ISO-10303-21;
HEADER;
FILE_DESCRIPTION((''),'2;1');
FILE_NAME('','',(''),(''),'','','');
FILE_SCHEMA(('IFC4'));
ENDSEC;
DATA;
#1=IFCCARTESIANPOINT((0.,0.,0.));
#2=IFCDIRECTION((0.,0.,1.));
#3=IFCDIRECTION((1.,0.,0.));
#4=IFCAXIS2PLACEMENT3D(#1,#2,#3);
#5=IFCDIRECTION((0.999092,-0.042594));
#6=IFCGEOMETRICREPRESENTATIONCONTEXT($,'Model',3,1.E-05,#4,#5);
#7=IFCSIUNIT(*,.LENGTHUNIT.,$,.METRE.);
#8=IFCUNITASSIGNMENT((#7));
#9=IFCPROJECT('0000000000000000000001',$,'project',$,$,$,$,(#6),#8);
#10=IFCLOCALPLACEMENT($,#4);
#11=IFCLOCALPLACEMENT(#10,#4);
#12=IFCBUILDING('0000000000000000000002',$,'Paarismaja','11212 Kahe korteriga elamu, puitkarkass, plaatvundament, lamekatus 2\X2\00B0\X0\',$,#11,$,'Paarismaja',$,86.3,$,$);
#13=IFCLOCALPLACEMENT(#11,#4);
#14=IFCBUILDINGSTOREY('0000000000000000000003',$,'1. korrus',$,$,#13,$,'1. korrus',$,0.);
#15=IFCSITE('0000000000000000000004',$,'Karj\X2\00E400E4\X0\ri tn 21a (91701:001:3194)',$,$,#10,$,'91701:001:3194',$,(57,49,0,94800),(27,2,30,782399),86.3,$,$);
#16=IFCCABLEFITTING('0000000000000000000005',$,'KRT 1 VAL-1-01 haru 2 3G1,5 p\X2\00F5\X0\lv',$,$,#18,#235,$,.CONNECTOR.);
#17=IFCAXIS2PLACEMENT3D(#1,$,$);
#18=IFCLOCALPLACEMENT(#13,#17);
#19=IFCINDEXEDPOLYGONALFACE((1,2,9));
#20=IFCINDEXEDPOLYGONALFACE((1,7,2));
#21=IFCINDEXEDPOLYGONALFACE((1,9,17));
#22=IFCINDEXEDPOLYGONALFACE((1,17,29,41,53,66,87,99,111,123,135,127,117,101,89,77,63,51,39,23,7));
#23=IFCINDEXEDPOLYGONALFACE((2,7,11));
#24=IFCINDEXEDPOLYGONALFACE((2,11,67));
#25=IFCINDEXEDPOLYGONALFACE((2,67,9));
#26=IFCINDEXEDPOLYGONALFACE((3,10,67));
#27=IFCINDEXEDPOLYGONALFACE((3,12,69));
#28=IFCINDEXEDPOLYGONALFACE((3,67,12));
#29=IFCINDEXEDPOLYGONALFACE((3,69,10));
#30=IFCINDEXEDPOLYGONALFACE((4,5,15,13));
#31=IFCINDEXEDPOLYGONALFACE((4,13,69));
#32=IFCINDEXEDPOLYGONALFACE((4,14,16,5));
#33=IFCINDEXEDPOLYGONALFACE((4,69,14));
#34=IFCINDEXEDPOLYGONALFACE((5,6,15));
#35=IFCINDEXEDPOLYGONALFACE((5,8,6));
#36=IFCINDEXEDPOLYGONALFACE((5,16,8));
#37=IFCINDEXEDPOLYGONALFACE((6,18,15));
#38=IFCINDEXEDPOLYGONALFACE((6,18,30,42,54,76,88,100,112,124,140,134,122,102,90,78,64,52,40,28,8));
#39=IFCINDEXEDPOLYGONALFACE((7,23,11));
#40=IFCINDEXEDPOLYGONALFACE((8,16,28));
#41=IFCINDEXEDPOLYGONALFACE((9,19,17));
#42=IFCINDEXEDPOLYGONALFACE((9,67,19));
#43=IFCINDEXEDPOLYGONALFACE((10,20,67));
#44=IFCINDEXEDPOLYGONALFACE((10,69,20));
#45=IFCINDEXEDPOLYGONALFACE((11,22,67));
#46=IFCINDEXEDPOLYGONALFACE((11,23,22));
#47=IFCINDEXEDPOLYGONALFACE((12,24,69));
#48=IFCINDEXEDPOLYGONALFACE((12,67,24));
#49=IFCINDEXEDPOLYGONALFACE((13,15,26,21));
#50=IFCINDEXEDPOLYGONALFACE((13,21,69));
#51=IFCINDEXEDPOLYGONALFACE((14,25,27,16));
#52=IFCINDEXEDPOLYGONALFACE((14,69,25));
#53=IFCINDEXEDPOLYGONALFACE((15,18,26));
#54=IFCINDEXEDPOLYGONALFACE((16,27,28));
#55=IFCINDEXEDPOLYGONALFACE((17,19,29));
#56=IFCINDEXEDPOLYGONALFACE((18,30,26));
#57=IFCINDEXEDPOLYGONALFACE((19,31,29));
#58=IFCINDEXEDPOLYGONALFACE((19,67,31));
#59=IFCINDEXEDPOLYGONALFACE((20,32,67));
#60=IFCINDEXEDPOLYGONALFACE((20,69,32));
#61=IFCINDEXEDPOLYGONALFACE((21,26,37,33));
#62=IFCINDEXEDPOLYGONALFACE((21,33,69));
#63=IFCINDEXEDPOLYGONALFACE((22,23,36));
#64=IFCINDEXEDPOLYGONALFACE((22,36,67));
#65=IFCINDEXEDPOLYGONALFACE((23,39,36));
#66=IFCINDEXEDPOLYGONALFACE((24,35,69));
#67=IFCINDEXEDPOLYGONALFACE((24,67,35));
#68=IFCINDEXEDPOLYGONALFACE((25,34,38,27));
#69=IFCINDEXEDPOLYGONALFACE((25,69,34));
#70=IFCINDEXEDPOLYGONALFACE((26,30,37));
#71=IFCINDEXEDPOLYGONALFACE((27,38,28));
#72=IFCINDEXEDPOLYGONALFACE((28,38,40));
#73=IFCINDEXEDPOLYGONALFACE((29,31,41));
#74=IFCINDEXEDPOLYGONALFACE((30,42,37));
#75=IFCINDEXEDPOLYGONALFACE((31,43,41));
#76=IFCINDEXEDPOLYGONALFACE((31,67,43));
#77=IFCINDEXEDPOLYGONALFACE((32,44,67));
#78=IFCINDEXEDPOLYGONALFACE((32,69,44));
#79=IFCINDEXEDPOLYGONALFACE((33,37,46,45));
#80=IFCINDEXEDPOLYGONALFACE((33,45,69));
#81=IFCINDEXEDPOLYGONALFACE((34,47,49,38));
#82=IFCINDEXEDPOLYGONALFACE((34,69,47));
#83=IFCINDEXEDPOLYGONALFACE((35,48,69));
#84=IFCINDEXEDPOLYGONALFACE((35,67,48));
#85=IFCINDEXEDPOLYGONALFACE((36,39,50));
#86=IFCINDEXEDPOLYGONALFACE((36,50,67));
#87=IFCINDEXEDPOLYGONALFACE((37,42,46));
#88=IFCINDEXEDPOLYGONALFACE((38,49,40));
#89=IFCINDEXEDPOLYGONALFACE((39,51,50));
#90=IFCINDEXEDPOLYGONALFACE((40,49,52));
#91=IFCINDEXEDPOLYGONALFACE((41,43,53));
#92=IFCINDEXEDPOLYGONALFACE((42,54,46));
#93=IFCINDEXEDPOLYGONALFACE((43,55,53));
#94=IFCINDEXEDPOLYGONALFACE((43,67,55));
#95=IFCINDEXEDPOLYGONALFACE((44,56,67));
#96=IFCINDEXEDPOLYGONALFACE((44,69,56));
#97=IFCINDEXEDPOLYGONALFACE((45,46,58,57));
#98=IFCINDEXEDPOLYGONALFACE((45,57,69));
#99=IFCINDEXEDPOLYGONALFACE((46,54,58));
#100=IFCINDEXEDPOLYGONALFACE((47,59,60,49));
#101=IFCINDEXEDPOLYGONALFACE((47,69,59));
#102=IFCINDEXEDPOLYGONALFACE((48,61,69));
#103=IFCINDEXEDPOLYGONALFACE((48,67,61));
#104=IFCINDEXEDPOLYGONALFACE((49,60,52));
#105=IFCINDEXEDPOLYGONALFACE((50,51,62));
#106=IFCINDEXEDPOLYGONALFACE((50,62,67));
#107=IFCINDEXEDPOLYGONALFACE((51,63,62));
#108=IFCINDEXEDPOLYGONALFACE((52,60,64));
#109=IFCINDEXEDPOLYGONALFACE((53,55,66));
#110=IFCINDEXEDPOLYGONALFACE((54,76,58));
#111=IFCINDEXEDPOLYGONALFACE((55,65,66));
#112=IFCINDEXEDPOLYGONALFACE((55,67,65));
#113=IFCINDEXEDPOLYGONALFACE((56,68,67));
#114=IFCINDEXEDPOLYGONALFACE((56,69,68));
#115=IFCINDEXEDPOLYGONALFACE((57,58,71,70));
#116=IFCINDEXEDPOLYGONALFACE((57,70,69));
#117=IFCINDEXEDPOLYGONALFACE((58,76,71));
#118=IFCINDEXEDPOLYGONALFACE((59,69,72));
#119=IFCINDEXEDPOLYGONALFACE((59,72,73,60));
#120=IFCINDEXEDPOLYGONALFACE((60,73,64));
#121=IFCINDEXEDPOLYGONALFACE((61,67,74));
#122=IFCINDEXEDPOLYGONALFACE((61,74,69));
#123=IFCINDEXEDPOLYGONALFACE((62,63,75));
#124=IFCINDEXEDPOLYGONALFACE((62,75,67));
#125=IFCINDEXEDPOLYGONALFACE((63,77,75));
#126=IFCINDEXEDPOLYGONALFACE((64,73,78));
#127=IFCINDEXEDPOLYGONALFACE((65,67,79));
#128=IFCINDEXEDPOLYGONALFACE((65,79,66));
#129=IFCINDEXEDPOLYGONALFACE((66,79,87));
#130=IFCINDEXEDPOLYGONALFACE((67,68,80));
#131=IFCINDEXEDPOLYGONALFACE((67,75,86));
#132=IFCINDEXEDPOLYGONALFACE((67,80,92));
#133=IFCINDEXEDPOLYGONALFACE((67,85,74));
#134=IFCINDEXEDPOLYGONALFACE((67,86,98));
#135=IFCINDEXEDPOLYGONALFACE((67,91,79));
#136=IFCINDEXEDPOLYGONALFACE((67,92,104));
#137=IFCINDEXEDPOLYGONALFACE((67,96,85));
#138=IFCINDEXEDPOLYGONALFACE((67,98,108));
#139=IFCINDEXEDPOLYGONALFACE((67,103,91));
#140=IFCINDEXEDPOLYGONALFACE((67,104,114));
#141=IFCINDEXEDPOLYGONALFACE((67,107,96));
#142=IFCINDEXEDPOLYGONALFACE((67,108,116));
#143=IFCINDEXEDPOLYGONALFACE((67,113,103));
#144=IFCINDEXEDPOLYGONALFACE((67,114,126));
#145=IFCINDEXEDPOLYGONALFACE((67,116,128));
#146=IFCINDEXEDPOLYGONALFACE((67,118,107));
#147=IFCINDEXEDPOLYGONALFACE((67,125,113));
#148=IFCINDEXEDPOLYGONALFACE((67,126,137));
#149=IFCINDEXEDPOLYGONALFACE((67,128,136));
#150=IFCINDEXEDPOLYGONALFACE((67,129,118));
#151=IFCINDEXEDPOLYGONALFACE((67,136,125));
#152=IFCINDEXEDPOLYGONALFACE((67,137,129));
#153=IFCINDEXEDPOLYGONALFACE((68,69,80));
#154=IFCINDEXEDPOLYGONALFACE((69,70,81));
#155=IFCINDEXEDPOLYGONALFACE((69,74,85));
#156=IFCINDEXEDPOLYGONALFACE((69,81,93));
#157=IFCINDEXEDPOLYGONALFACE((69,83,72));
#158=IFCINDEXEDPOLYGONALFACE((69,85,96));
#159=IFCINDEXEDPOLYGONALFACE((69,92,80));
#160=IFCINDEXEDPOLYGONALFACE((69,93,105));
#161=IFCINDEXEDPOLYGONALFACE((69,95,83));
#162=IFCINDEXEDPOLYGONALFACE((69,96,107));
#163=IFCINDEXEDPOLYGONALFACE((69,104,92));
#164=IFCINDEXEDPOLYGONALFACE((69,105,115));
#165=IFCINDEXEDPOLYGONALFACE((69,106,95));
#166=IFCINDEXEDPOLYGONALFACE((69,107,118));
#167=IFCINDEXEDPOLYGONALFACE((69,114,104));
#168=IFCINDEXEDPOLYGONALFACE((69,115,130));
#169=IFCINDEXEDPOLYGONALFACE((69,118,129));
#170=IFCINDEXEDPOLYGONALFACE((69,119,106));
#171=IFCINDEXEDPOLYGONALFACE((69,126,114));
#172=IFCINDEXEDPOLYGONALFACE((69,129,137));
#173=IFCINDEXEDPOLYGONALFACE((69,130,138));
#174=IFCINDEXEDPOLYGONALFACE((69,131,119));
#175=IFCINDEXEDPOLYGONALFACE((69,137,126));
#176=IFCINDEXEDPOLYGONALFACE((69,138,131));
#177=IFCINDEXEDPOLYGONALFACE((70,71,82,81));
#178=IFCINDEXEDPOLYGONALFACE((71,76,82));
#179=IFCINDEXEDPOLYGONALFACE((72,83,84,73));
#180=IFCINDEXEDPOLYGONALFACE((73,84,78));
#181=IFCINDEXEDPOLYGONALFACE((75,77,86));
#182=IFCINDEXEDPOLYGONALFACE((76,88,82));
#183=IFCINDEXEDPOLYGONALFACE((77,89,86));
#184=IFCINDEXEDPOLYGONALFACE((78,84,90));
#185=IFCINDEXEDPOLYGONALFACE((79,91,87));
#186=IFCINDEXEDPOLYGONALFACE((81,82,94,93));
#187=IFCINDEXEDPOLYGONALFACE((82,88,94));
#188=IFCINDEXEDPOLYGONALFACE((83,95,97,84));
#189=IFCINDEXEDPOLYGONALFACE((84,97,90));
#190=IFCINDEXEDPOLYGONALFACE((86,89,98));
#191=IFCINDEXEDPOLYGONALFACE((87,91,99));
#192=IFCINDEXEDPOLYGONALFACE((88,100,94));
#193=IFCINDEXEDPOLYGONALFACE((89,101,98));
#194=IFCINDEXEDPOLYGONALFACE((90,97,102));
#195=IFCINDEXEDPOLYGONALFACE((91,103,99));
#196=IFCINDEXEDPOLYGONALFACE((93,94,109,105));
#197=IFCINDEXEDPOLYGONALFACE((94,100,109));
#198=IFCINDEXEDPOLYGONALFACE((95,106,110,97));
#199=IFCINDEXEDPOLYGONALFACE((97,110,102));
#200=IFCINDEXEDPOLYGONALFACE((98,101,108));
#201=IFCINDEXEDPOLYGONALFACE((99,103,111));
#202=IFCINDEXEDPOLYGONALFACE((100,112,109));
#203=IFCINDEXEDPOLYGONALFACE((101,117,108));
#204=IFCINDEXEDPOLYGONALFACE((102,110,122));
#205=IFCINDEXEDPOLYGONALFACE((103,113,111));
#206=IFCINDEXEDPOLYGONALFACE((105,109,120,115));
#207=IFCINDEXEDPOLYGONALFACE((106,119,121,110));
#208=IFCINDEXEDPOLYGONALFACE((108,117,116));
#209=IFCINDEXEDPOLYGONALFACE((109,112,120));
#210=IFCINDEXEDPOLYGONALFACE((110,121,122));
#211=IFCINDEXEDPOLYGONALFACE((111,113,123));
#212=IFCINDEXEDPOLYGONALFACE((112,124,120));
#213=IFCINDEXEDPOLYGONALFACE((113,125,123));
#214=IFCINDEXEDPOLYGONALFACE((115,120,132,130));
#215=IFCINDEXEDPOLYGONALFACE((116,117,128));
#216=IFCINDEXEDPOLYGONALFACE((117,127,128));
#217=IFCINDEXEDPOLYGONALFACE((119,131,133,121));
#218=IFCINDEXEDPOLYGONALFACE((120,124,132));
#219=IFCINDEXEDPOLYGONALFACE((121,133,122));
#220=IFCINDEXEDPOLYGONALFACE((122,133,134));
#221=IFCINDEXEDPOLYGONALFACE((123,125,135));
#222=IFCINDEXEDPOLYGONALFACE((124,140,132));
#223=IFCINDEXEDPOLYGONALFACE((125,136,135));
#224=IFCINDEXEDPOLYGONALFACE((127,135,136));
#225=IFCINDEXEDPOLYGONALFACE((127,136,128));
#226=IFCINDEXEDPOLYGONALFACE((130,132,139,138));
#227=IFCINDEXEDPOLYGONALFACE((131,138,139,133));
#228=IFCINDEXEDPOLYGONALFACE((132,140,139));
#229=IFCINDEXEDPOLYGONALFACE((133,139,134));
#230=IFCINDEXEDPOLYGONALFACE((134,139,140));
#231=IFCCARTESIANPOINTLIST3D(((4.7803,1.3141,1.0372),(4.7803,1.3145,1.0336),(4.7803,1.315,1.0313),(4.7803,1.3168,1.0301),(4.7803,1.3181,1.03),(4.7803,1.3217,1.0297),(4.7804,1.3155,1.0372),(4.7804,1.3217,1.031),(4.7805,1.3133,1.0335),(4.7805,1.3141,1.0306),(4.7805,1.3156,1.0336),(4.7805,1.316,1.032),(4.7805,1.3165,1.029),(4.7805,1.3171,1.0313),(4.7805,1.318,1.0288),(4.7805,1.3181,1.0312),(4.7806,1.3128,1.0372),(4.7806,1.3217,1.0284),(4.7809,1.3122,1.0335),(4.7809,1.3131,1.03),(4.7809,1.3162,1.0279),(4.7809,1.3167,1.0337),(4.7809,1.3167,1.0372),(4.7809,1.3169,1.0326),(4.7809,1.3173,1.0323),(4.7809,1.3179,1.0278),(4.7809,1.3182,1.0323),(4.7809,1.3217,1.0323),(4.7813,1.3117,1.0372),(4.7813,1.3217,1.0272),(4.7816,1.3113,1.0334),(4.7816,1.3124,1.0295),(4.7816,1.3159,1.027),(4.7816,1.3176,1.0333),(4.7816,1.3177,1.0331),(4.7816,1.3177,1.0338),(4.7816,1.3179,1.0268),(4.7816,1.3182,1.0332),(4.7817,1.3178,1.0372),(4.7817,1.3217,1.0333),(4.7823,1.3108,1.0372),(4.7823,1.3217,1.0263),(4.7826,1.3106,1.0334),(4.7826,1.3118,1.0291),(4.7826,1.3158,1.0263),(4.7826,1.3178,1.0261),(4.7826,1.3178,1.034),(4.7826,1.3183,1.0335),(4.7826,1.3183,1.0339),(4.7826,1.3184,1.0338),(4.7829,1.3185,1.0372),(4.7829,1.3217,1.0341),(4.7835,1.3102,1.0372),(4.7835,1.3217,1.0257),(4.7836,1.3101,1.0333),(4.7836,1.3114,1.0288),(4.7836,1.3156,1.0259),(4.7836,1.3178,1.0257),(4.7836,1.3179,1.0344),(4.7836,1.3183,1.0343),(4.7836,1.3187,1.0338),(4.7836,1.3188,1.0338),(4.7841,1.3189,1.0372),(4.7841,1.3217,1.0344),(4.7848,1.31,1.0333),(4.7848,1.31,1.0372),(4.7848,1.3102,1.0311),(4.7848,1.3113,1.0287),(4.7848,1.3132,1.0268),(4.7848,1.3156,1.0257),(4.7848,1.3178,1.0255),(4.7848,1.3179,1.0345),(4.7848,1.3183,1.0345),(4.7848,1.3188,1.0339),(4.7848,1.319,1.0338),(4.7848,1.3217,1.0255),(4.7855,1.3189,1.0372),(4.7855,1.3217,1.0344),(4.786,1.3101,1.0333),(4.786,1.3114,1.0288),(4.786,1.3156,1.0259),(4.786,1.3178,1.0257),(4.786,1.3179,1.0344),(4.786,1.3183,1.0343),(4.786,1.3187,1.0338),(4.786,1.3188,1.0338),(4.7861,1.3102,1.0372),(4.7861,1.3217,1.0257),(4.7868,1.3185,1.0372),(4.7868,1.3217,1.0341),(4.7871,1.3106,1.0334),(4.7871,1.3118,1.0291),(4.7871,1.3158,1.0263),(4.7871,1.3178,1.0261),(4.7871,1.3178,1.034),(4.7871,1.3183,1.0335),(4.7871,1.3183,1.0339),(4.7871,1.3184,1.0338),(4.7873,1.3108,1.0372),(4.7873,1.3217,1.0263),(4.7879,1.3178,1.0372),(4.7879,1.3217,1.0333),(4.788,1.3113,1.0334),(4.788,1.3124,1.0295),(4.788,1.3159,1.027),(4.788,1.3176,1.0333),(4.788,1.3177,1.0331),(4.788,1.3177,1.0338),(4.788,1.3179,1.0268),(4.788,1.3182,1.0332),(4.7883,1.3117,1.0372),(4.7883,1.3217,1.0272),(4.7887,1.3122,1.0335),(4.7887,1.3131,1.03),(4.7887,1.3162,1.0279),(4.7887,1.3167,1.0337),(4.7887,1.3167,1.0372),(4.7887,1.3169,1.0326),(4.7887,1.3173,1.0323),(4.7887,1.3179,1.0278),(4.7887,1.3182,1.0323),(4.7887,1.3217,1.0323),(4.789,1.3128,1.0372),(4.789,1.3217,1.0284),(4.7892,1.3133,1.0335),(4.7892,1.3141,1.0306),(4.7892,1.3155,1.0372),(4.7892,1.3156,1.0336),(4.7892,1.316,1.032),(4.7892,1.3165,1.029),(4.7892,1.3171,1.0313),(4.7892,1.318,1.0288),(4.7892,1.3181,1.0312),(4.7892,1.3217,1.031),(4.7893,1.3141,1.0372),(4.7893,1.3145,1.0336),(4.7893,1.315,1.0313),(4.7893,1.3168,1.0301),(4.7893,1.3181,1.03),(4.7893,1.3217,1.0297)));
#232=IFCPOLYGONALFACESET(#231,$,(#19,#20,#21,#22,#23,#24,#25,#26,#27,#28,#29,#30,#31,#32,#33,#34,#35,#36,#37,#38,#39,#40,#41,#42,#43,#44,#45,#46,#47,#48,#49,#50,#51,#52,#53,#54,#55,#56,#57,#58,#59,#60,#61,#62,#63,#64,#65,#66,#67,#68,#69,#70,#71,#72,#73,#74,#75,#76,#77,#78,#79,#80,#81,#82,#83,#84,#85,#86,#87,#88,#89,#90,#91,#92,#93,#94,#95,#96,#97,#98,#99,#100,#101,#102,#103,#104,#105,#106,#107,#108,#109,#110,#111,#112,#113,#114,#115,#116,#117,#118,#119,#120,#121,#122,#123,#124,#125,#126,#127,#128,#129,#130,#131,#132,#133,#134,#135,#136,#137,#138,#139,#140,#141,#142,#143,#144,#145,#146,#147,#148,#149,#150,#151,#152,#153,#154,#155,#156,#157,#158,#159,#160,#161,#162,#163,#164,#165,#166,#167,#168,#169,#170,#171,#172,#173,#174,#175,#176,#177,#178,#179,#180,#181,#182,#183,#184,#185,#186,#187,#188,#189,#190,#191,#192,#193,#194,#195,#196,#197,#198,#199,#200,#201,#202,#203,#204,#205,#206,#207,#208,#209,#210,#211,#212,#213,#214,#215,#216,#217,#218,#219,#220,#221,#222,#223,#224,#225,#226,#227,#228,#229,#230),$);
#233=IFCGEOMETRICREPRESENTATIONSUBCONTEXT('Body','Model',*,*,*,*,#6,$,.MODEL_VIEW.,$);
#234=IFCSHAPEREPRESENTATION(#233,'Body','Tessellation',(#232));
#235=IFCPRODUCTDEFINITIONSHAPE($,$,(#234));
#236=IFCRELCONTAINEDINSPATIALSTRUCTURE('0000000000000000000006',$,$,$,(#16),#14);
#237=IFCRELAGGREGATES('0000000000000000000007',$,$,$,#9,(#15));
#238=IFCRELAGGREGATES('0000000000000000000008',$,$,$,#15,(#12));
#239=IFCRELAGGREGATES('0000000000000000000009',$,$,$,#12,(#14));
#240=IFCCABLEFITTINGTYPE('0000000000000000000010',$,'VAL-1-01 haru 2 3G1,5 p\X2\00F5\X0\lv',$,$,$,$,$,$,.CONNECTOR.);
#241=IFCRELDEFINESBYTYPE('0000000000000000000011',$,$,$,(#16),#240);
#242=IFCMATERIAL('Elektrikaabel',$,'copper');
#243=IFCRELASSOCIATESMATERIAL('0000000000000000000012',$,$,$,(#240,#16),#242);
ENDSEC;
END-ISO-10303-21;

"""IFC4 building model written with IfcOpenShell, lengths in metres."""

from ifc_helpers import new_model, entity, si_unit, direction, frame, origin_with_axes, place, context, subcontext, project, spatial, material, type_object, element, save


model = new_model("IFC4")

# Units and contexts
model_context = context("Model", 3, precision=1e-05, world=origin_with_axes(), true_north=direction((0.999092, -0.042594)))
body_context = subcontext(model_context, "Body", "Model", "MODEL_VIEW")
ifc_project = project(units=[si_unit("LENGTHUNIT", "METRE")], contexts=[model_context])

# Site, building, storey
site_placement = place(None, origin_with_axes())
site = spatial("IfcSite", under=ifc_project, at=site_placement, Name="Karjääri tn 21a (91701:001:3194)", LongName="91701:001:3194", RefLatitude=(57, 49, 0, 94800), RefLongitude=(27, 2, 30, 782399), RefElevation=86.3)
building_placement = place(site_placement, origin_with_axes())
building = spatial("IfcBuilding", under=site, at=building_placement, Name="Paarismaja", Description="11212 Kahe korteriga elamu, puitkarkass, plaatvundament, lamekatus 2°", LongName="Paarismaja", ElevationOfRefHeight=86.3)
storey_placement = place(building_placement, origin_with_axes())
storey = spatial("IfcBuildingStorey", under=building, at=storey_placement, Name="1. korrus", LongName="1. korrus", Elevation=0.0)

# Cable fitting
ifc_material_1 = material(Name="Elektrikaabel", Category="copper")
cable_fitting_type_1 = type_object("IfcCableFittingType", Name="VAL-1-01 haru 2 3G1,5 põlv", PredefinedType="CONNECTOR", material=ifc_material_1)
cable_fitting_1_placement = place(storey_placement, frame((4.7848, 1.3145, 1.03), z_axis=(0.0, 0.0, 1.0), x_axis=(1.0, 0.0, 0.0)))
element("IfcCableFitting", 1, at=cable_fitting_1_placement, inside=storey, type_object=cable_fitting_type_1, material=ifc_material_1, Name="KRT 1 VAL-1-01 haru 2 3G1,5 põlv", PredefinedType="CONNECTOR", context=body_context, shape_type="AdvancedSweptSolid", body=[
    entity("IfcSweptDiskSolid", entity("IfcIndexedPolyCurve", entity("IfcCartesianPointList3D", [[0.0, 0.0072, 0.0], [0.0, 0.0036, 0.0], [0.0, 0.0023, 0.0001], [0.0, 0.0013, 0.0006], [0.0, 0.0006, 0.0013], [0.0, 0.0001, 0.0023], [0.0, 0.0, 0.0036], [0.0, 0.0, 0.0072]]), None, False), 0.0045),
])

save(model, "model.ifc")
